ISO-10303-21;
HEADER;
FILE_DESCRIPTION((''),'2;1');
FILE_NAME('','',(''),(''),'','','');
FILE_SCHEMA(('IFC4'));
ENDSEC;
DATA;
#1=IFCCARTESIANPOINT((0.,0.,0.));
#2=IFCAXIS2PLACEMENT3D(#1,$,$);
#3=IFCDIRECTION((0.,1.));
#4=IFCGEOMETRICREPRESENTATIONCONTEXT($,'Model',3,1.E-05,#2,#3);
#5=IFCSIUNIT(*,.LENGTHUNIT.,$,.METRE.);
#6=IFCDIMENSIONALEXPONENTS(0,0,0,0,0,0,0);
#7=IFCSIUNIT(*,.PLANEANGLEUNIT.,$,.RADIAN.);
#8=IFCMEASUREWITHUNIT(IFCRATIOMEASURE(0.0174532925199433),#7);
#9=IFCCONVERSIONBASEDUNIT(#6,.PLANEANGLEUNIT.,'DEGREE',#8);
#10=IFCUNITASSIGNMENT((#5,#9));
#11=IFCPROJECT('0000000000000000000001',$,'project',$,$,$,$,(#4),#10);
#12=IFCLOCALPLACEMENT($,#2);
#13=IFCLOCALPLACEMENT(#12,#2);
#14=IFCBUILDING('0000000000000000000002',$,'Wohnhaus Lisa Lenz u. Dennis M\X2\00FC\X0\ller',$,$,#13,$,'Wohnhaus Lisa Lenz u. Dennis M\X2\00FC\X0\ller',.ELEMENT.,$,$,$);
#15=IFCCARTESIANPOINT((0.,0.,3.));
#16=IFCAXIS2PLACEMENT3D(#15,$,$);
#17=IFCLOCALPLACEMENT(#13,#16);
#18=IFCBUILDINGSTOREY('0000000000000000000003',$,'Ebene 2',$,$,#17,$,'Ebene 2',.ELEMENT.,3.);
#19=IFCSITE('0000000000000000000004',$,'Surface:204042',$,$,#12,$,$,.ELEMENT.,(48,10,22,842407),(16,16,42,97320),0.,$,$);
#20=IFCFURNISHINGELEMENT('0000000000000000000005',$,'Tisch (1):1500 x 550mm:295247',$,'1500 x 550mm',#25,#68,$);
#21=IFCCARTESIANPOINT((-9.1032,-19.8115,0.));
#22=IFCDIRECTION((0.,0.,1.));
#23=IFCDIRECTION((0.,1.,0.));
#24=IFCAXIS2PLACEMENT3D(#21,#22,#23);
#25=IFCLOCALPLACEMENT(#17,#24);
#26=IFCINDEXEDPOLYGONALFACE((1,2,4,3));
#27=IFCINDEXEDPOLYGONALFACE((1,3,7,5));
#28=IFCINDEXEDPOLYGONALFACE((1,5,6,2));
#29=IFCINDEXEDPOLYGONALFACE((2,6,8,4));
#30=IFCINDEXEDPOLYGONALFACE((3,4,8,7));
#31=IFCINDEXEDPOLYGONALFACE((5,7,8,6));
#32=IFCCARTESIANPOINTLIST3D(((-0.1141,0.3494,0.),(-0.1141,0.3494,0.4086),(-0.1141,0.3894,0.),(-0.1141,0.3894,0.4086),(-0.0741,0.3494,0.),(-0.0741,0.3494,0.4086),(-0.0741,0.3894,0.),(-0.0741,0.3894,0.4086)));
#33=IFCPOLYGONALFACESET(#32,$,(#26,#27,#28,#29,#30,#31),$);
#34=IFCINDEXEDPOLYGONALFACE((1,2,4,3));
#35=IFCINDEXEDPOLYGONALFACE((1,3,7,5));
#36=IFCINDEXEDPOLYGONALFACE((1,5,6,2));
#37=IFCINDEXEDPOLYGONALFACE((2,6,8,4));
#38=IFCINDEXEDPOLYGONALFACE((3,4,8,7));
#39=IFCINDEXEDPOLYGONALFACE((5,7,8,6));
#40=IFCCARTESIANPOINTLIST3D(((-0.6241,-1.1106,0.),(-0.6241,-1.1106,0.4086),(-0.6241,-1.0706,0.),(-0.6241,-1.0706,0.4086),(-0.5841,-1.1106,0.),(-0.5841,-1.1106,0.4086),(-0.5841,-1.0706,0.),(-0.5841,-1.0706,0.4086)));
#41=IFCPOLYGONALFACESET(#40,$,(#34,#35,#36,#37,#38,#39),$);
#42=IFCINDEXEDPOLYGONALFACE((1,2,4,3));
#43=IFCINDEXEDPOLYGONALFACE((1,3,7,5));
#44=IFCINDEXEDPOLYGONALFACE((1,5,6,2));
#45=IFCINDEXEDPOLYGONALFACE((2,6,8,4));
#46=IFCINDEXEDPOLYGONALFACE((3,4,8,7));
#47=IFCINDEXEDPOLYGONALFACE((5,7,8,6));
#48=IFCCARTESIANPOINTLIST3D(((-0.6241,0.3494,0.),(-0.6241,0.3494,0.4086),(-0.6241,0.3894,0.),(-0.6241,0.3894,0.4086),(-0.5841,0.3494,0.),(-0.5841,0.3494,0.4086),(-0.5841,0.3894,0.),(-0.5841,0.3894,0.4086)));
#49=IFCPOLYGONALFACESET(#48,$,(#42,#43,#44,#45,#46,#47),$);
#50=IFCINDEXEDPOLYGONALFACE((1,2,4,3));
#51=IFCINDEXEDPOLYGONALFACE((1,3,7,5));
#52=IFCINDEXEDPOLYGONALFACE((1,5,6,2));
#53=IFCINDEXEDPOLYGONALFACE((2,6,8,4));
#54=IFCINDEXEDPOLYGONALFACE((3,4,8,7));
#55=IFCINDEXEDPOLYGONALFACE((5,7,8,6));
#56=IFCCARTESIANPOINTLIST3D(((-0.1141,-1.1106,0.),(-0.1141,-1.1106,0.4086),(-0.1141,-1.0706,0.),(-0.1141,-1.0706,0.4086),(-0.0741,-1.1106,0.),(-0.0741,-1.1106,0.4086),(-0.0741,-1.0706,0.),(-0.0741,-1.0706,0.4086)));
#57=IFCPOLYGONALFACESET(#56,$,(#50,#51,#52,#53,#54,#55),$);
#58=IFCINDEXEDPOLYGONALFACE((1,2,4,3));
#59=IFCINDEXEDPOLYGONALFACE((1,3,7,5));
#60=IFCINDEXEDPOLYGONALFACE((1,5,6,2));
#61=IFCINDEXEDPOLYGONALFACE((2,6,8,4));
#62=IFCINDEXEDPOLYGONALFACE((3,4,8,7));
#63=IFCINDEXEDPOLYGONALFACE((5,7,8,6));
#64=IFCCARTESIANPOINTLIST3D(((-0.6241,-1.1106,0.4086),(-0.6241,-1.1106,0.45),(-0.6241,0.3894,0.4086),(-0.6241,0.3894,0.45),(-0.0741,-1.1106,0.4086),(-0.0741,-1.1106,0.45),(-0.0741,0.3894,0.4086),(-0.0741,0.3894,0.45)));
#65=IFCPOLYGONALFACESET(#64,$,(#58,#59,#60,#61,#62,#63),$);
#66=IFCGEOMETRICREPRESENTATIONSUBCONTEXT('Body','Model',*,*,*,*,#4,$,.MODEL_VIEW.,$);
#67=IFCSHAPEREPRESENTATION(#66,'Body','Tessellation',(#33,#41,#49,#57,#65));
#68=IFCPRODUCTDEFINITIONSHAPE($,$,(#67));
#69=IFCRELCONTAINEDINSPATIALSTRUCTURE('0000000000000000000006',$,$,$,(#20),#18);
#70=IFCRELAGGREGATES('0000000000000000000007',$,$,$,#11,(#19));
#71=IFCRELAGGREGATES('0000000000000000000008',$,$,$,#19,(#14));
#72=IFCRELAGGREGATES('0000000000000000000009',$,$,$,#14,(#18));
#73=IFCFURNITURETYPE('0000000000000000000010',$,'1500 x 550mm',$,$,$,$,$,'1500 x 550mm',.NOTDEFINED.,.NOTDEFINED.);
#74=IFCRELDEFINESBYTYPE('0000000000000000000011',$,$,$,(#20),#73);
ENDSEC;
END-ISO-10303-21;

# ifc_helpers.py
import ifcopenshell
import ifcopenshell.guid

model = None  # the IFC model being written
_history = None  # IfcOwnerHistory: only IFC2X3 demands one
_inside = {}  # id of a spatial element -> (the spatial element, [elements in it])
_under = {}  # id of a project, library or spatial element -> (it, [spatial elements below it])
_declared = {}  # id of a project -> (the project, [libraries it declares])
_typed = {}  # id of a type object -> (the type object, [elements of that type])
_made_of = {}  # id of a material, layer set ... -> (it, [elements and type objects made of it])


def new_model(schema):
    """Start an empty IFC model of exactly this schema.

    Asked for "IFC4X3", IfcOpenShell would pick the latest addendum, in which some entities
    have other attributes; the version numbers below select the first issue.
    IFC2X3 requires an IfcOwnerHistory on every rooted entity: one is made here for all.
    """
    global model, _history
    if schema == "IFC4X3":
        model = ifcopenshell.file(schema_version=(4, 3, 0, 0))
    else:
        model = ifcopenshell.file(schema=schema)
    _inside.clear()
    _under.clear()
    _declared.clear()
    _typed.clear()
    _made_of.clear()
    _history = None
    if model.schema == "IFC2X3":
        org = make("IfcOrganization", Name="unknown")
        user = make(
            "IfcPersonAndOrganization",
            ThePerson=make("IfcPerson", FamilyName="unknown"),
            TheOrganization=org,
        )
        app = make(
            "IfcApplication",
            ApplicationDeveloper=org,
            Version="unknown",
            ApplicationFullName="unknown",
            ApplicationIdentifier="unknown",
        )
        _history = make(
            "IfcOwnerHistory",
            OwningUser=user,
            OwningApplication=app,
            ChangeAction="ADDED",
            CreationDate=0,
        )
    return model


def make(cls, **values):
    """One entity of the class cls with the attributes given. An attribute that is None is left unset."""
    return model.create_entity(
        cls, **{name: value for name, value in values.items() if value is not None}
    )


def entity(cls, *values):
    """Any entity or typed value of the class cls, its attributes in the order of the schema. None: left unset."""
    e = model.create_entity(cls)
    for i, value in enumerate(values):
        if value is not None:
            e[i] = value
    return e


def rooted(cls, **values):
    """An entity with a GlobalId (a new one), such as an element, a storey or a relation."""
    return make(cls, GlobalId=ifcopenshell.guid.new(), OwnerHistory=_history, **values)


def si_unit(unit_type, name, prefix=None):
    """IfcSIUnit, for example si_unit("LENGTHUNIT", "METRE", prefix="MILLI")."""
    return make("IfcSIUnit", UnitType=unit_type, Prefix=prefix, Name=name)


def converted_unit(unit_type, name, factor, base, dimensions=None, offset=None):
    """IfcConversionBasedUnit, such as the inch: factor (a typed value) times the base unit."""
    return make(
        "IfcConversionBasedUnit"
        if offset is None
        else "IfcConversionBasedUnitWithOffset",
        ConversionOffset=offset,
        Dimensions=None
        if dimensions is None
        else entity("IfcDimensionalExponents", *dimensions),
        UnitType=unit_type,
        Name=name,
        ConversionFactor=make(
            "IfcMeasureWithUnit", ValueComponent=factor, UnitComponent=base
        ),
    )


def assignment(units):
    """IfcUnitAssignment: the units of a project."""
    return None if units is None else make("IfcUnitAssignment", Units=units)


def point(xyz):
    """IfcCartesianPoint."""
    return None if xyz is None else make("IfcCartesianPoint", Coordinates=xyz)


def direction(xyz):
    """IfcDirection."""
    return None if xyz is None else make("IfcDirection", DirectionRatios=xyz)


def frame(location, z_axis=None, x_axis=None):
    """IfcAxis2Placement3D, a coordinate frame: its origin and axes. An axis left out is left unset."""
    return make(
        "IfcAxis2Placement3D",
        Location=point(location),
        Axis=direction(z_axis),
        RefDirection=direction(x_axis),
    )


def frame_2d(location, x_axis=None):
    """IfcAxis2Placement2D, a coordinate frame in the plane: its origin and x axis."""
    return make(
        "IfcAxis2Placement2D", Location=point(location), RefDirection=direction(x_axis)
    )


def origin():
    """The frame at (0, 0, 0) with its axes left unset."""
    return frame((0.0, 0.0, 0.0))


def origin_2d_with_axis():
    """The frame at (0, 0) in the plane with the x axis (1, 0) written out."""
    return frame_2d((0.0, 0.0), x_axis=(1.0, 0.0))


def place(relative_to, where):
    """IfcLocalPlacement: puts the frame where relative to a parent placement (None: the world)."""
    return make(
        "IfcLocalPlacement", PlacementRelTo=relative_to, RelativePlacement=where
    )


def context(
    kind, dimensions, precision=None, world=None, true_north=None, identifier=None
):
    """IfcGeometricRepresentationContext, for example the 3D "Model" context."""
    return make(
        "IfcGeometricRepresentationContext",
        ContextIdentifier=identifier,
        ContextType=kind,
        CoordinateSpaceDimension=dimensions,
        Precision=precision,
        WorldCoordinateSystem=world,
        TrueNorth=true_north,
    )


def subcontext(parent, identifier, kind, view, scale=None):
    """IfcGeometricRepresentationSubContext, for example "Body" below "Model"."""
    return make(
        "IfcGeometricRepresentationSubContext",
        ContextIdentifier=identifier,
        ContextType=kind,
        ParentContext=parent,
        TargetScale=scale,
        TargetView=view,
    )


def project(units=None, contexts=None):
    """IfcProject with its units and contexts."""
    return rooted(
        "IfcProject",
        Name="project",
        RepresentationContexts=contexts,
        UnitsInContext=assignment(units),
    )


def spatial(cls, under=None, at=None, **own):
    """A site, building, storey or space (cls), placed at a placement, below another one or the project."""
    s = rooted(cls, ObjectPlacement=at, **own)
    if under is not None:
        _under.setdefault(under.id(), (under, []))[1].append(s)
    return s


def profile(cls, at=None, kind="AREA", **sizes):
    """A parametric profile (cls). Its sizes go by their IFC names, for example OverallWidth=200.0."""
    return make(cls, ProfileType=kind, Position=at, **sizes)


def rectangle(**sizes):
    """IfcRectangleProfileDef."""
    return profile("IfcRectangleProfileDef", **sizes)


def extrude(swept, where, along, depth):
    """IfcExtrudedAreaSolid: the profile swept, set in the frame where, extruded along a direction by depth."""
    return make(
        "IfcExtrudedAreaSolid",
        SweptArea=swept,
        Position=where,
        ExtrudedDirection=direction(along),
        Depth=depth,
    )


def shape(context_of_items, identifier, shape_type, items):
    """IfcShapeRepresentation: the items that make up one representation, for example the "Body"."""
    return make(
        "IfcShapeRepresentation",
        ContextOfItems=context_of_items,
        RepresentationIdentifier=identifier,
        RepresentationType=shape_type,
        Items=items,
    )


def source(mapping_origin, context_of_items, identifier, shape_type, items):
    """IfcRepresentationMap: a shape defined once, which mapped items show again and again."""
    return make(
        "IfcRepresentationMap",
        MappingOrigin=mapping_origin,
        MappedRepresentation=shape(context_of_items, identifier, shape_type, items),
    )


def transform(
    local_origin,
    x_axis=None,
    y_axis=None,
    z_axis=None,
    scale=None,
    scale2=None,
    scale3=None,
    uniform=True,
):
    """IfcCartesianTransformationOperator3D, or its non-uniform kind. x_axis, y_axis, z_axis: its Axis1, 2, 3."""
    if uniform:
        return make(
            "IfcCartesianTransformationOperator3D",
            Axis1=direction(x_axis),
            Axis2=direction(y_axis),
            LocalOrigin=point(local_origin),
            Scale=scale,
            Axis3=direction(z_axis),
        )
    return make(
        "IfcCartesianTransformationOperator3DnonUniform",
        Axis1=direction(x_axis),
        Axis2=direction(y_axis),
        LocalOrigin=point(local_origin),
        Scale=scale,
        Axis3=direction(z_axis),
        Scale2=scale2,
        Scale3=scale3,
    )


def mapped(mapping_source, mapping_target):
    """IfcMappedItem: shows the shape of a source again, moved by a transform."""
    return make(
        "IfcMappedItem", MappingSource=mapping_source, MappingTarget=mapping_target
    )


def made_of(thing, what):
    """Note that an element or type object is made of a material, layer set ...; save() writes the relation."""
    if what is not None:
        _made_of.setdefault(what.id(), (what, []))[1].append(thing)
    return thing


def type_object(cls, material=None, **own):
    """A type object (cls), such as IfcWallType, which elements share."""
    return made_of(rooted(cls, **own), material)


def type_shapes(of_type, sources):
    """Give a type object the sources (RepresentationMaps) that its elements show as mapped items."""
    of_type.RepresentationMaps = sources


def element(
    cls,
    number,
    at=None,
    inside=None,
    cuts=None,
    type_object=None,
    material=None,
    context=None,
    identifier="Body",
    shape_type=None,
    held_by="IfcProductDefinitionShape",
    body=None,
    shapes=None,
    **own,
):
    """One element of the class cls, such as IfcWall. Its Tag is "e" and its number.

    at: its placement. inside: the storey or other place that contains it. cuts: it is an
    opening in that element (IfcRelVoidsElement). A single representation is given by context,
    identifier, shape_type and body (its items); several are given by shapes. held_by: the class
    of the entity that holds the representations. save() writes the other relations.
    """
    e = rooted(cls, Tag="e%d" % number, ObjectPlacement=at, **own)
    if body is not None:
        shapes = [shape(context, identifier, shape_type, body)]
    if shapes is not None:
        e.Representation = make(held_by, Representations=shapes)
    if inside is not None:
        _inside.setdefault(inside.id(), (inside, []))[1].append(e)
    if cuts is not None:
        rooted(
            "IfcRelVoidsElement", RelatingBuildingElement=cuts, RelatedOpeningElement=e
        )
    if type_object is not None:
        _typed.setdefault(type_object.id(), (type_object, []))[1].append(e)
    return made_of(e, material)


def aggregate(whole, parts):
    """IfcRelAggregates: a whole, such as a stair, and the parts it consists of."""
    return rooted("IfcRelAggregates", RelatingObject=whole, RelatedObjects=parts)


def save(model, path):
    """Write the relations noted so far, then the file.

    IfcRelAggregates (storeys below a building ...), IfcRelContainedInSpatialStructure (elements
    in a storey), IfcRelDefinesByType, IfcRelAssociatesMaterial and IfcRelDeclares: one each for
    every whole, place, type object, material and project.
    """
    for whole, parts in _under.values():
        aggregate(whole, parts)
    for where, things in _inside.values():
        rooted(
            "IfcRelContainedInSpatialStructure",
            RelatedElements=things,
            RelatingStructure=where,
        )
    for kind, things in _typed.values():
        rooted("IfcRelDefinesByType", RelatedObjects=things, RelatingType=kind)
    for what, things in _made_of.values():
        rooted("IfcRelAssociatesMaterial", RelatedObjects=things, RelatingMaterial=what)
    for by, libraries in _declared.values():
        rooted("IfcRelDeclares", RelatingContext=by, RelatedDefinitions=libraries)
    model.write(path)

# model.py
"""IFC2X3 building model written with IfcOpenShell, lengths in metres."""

from ifc_helpers import new_model, entity, si_unit, converted_unit, direction, frame, origin, origin_2d_with_axis, place, context, subcontext, project, spatial, rectangle, extrude, source, transform, mapped, type_object, type_shapes, element, save


model = new_model("IFC2X3")

# Units and contexts
model_context = context("Model", 3, precision=1e-05, world=origin(), true_north=direction((0.0, 1.0)))
body_context = subcontext(model_context, "Body", "Model", "MODEL_VIEW")
ifc_project = project(units=[si_unit("LENGTHUNIT", "METRE"), converted_unit("PLANEANGLEUNIT", "DEGREE", entity("IfcRatioMeasure", 0.0174532925199433), si_unit("PLANEANGLEUNIT", "RADIAN"), dimensions=[0, 0, 0, 0, 0, 0, 0])], contexts=[model_context])

# Site, building, storey
site_placement = place(None, origin())
site = spatial("IfcSite", under=ifc_project, at=site_placement, Name="Surface:204042", CompositionType="ELEMENT", RefLatitude=(48, 10, 22, 842407), RefLongitude=(16, 16, 42, 97320), RefElevation=0.0)
building_placement = place(site_placement, origin())
building = spatial("IfcBuilding", under=site, at=building_placement, Name="Wohnhaus Lisa Lenz u. Dennis Müller", LongName="Wohnhaus Lisa Lenz u. Dennis Müller", CompositionType="ELEMENT")
storey_placement = place(building_placement, frame((0.0, 0.0, 3.0)))
storey = spatial("IfcBuildingStorey", under=building, at=storey_placement, Name="Ebene 2", LongName="Ebene 2", CompositionType="ELEMENT", Elevation=3.0)

# Furnishing element
furniture_type_1 = type_object("IfcFurnitureType", Name="1500 x 550mm", ElementType="1500 x 550mm")
shared_shape_1 = source(origin(), body_context, "Body", "SweptSolid", [
    extrude(rectangle(XDim=0.04, YDim=0.04, at=origin_2d_with_axis()), frame((-0.0941, 0.3694, 0.0), z_axis=(0.0, 0.0, 1.0), x_axis=(-1.0, 0.0, 0.0)), (0.0, 0.0, 1.0), 0.4086),
    extrude(rectangle(XDim=0.04, YDim=0.04, at=origin_2d_with_axis()), frame((-0.6041, -1.0906, 0.0), z_axis=(0.0, 0.0, 1.0), x_axis=(0.0, -1.0, 0.0)), (0.0, 0.0, 1.0), 0.4086),
    extrude(rectangle(XDim=0.04, YDim=0.04, at=origin_2d_with_axis()), frame((-0.6041, 0.3694, 0.0), z_axis=(0.0, 0.0, 1.0), x_axis=(-1.0, 0.0, 0.0)), (0.0, 0.0, 1.0), 0.4086),
    extrude(rectangle(XDim=0.04, YDim=0.04, at=origin_2d_with_axis()), frame((-0.0941, -1.0906, 0.0), z_axis=(0.0, 0.0, 1.0), x_axis=(-1.0, 0.0, 0.0)), (0.0, 0.0, 1.0), 0.4086),
    extrude(rectangle(XDim=0.55, YDim=1.5, at=origin_2d_with_axis()), frame((-0.3491, -0.3606, 0.4086), z_axis=(0.0, 0.0, 1.0), x_axis=(-1.0, 0.0, 0.0)), (0.0, 0.0, 1.0), 0.0414),
])
type_shapes(furniture_type_1, [shared_shape_1])
furnishing_1_placement = place(storey_placement, frame((-9.1032, -19.8115, 0.0), z_axis=(0.0, 0.0, 1.0), x_axis=(0.0, 1.0, 0.0)))
element("IfcFurnishingElement", 1, at=furnishing_1_placement, inside=storey, type_object=furniture_type_1, Name="Tisch (1):1500 x 550mm:295247", ObjectType="1500 x 550mm", context=body_context, shape_type="MappedRepresentation", body=[
    mapped(shared_shape_1, transform((0.0, 0.0, 0.0), scale=1.0)),
])

save(model, "model.ifc")
